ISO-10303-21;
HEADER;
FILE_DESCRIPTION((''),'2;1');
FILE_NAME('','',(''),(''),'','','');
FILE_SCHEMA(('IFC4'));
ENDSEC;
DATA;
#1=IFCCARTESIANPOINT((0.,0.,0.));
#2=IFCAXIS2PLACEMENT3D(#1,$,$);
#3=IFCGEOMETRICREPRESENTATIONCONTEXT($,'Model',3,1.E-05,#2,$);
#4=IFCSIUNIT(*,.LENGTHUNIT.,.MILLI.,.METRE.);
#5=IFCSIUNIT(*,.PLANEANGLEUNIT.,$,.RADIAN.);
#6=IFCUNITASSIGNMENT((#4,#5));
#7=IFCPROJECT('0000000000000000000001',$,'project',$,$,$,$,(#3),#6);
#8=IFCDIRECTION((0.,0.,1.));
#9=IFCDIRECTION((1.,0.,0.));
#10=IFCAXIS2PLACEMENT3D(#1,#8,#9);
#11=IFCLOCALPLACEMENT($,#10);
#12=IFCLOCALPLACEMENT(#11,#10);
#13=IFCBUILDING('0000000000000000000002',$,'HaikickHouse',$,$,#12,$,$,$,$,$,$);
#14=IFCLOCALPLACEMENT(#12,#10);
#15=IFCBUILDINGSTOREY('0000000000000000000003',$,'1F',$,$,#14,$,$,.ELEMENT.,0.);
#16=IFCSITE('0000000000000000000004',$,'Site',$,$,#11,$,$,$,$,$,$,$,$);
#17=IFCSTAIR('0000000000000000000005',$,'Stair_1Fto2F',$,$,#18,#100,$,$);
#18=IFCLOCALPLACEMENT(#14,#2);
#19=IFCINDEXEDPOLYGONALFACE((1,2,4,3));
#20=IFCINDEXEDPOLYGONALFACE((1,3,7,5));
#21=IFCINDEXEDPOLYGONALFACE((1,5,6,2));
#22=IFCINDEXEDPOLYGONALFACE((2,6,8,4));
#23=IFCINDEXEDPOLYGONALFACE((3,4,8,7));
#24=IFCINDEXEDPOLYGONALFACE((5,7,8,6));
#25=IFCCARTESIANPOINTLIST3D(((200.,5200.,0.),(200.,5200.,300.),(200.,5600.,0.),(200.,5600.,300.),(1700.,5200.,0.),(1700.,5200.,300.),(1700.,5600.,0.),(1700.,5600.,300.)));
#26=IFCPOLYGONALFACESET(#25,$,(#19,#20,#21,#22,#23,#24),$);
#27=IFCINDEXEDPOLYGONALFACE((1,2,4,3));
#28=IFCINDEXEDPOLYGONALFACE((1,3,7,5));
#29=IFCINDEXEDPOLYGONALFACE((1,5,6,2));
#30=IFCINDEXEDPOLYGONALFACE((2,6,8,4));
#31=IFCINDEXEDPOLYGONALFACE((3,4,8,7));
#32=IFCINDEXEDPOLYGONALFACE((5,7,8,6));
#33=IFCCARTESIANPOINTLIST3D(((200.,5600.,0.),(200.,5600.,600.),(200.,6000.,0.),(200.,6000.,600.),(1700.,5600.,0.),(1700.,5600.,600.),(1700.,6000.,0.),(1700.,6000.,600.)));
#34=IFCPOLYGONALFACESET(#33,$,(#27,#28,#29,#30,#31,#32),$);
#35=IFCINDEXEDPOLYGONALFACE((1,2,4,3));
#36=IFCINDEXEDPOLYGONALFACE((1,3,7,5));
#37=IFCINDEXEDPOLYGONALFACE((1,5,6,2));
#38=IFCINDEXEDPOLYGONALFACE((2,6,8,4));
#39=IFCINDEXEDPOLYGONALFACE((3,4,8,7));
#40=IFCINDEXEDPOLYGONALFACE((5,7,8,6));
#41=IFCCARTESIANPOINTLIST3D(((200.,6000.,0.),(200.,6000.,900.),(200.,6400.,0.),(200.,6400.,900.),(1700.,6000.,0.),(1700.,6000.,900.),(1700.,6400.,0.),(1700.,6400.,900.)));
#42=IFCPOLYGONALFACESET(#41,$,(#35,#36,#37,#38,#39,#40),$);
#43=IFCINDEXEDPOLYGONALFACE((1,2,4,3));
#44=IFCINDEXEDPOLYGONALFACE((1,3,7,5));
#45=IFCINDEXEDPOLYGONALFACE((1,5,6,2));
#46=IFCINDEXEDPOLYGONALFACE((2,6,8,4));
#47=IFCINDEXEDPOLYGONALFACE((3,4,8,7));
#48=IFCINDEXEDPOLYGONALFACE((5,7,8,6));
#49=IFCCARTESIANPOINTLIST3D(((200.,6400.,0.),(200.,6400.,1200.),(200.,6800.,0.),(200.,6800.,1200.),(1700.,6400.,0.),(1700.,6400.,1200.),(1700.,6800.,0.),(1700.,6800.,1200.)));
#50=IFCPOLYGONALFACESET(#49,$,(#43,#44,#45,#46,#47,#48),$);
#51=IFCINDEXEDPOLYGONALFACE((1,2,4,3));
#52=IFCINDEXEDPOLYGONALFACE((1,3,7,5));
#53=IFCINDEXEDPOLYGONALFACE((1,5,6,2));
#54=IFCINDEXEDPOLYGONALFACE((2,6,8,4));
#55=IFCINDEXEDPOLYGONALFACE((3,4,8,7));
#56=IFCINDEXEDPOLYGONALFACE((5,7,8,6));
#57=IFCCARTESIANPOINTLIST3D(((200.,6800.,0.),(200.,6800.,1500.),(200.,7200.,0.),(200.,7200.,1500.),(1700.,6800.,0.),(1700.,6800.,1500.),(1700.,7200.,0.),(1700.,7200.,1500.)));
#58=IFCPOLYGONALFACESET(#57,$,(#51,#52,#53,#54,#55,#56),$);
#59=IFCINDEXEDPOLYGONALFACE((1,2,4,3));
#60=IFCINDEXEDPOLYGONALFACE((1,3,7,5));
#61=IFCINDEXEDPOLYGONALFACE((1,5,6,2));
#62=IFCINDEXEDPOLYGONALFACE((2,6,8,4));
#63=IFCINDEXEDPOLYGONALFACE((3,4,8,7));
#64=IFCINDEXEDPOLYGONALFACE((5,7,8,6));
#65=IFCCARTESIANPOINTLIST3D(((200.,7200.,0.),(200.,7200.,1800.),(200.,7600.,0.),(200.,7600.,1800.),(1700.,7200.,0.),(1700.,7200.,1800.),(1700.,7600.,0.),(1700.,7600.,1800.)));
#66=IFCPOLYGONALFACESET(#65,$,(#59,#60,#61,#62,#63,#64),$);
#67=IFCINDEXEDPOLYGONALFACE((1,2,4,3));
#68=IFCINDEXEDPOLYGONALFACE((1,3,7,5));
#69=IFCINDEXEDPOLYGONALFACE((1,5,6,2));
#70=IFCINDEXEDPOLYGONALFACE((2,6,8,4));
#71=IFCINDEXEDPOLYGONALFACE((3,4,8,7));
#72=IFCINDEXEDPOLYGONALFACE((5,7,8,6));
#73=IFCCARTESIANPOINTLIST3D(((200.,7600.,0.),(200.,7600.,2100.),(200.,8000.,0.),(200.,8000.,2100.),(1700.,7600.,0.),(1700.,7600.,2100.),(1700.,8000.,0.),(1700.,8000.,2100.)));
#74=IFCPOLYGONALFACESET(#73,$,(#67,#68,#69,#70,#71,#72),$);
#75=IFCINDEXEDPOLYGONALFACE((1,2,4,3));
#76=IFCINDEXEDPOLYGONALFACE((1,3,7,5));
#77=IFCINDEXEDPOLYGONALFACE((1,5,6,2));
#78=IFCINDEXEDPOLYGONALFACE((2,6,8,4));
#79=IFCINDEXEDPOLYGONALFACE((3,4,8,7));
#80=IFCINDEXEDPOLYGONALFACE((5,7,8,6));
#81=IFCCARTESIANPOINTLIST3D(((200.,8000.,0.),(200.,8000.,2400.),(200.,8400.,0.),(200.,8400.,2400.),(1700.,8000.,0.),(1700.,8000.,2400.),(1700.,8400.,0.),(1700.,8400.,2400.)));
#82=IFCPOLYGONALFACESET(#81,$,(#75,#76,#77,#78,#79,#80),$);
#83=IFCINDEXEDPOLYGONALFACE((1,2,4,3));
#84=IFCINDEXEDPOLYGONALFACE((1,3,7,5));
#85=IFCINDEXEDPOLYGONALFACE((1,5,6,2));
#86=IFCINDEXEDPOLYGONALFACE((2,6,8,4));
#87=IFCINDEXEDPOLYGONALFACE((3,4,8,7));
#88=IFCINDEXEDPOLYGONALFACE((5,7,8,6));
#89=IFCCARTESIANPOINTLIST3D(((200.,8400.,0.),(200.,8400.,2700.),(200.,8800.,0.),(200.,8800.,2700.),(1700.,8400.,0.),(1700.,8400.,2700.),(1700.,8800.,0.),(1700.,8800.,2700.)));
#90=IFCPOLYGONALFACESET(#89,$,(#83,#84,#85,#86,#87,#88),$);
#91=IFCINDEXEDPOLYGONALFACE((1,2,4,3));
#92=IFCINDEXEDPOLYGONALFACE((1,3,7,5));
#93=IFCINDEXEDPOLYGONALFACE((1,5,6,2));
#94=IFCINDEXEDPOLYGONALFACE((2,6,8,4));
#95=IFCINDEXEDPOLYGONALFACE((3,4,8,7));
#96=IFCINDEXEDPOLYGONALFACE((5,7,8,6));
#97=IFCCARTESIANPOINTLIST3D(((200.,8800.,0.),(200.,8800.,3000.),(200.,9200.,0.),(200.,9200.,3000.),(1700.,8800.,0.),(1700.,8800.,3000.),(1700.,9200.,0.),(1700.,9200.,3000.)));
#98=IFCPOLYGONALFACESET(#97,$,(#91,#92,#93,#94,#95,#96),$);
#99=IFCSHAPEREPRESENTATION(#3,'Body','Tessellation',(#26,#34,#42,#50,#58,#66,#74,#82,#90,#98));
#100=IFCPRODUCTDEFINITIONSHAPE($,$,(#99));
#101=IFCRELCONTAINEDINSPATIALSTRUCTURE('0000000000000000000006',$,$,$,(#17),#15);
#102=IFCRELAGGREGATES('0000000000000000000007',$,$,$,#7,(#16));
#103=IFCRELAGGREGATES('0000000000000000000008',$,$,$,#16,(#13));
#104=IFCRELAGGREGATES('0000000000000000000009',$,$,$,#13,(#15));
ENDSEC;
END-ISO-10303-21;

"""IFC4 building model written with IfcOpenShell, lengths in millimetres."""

from ifc_helpers import new_model, si_unit, frame, origin, origin_with_axes, place, context, project, spatial, rectangle, extrude, element, save


model = new_model("IFC4")

# Units and contexts
model_context = context("Model", 3, precision=1e-05, world=origin())
ifc_project = project(units=[si_unit("LENGTHUNIT", "METRE", prefix="MILLI"), si_unit("PLANEANGLEUNIT", "RADIAN")], contexts=[model_context])

# Site, building, storey
site_placement = place(None, origin_with_axes())
site = spatial("IfcSite", under=ifc_project, at=site_placement, Name="Site")
building_placement = place(site_placement, origin_with_axes())
building = spatial("IfcBuilding", under=site, at=building_placement, Name="HaikickHouse")
storey_placement = place(building_placement, origin_with_axes())
storey = spatial("IfcBuildingStorey", under=building, at=storey_placement, Name="1F", CompositionType="ELEMENT", Elevation=0.0)

# Stair
stair_placement = place(None, frame((200.0, 5200.0, 0.0), z_axis=(0.0, 0.0, 1.0), x_axis=(1.0, 0.0, 0.0)))
element("IfcStair", 1, at=stair_placement, inside=storey, Name="Stair_1Fto2F", context=model_context, shape_type="SweptSolid", body=[
    extrude(rectangle(XDim=1500.0, YDim=400.0), frame((750.0, 200.0, 0.0)), (0.0, 0.0, 1.0), 300.0),
    extrude(rectangle(XDim=1500.0, YDim=400.0), frame((750.0, 600.0, 0.0)), (0.0, 0.0, 1.0), 600.0),
    extrude(rectangle(XDim=1500.0, YDim=400.0), frame((750.0, 1000.0, 0.0)), (0.0, 0.0, 1.0), 900.0),
    extrude(rectangle(XDim=1500.0, YDim=400.0), frame((750.0, 1400.0, 0.0)), (0.0, 0.0, 1.0), 1200.0),
    extrude(rectangle(XDim=1500.0, YDim=400.0), frame((750.0, 1800.0, 0.0)), (0.0, 0.0, 1.0), 1500.0),
    extrude(rectangle(XDim=1500.0, YDim=400.0), frame((750.0, 2200.0, 0.0)), (0.0, 0.0, 1.0), 1800.0),
    extrude(rectangle(XDim=1500.0, YDim=400.0), frame((750.0, 2600.0, 0.0)), (0.0, 0.0, 1.0), 2100.0),
    extrude(rectangle(XDim=1500.0, YDim=400.0), frame((750.0, 3000.0, 0.0)), (0.0, 0.0, 1.0), 2400.0),
    extrude(rectangle(XDim=1500.0, YDim=400.0), frame((750.0, 3400.0, 0.0)), (0.0, 0.0, 1.0), 2700.0),
    extrude(rectangle(XDim=1500.0, YDim=400.0), frame((750.0, 3800.0, 0.0)), (0.0, 0.0, 1.0), 3000.0),
])

save(model, "model.ifc")
